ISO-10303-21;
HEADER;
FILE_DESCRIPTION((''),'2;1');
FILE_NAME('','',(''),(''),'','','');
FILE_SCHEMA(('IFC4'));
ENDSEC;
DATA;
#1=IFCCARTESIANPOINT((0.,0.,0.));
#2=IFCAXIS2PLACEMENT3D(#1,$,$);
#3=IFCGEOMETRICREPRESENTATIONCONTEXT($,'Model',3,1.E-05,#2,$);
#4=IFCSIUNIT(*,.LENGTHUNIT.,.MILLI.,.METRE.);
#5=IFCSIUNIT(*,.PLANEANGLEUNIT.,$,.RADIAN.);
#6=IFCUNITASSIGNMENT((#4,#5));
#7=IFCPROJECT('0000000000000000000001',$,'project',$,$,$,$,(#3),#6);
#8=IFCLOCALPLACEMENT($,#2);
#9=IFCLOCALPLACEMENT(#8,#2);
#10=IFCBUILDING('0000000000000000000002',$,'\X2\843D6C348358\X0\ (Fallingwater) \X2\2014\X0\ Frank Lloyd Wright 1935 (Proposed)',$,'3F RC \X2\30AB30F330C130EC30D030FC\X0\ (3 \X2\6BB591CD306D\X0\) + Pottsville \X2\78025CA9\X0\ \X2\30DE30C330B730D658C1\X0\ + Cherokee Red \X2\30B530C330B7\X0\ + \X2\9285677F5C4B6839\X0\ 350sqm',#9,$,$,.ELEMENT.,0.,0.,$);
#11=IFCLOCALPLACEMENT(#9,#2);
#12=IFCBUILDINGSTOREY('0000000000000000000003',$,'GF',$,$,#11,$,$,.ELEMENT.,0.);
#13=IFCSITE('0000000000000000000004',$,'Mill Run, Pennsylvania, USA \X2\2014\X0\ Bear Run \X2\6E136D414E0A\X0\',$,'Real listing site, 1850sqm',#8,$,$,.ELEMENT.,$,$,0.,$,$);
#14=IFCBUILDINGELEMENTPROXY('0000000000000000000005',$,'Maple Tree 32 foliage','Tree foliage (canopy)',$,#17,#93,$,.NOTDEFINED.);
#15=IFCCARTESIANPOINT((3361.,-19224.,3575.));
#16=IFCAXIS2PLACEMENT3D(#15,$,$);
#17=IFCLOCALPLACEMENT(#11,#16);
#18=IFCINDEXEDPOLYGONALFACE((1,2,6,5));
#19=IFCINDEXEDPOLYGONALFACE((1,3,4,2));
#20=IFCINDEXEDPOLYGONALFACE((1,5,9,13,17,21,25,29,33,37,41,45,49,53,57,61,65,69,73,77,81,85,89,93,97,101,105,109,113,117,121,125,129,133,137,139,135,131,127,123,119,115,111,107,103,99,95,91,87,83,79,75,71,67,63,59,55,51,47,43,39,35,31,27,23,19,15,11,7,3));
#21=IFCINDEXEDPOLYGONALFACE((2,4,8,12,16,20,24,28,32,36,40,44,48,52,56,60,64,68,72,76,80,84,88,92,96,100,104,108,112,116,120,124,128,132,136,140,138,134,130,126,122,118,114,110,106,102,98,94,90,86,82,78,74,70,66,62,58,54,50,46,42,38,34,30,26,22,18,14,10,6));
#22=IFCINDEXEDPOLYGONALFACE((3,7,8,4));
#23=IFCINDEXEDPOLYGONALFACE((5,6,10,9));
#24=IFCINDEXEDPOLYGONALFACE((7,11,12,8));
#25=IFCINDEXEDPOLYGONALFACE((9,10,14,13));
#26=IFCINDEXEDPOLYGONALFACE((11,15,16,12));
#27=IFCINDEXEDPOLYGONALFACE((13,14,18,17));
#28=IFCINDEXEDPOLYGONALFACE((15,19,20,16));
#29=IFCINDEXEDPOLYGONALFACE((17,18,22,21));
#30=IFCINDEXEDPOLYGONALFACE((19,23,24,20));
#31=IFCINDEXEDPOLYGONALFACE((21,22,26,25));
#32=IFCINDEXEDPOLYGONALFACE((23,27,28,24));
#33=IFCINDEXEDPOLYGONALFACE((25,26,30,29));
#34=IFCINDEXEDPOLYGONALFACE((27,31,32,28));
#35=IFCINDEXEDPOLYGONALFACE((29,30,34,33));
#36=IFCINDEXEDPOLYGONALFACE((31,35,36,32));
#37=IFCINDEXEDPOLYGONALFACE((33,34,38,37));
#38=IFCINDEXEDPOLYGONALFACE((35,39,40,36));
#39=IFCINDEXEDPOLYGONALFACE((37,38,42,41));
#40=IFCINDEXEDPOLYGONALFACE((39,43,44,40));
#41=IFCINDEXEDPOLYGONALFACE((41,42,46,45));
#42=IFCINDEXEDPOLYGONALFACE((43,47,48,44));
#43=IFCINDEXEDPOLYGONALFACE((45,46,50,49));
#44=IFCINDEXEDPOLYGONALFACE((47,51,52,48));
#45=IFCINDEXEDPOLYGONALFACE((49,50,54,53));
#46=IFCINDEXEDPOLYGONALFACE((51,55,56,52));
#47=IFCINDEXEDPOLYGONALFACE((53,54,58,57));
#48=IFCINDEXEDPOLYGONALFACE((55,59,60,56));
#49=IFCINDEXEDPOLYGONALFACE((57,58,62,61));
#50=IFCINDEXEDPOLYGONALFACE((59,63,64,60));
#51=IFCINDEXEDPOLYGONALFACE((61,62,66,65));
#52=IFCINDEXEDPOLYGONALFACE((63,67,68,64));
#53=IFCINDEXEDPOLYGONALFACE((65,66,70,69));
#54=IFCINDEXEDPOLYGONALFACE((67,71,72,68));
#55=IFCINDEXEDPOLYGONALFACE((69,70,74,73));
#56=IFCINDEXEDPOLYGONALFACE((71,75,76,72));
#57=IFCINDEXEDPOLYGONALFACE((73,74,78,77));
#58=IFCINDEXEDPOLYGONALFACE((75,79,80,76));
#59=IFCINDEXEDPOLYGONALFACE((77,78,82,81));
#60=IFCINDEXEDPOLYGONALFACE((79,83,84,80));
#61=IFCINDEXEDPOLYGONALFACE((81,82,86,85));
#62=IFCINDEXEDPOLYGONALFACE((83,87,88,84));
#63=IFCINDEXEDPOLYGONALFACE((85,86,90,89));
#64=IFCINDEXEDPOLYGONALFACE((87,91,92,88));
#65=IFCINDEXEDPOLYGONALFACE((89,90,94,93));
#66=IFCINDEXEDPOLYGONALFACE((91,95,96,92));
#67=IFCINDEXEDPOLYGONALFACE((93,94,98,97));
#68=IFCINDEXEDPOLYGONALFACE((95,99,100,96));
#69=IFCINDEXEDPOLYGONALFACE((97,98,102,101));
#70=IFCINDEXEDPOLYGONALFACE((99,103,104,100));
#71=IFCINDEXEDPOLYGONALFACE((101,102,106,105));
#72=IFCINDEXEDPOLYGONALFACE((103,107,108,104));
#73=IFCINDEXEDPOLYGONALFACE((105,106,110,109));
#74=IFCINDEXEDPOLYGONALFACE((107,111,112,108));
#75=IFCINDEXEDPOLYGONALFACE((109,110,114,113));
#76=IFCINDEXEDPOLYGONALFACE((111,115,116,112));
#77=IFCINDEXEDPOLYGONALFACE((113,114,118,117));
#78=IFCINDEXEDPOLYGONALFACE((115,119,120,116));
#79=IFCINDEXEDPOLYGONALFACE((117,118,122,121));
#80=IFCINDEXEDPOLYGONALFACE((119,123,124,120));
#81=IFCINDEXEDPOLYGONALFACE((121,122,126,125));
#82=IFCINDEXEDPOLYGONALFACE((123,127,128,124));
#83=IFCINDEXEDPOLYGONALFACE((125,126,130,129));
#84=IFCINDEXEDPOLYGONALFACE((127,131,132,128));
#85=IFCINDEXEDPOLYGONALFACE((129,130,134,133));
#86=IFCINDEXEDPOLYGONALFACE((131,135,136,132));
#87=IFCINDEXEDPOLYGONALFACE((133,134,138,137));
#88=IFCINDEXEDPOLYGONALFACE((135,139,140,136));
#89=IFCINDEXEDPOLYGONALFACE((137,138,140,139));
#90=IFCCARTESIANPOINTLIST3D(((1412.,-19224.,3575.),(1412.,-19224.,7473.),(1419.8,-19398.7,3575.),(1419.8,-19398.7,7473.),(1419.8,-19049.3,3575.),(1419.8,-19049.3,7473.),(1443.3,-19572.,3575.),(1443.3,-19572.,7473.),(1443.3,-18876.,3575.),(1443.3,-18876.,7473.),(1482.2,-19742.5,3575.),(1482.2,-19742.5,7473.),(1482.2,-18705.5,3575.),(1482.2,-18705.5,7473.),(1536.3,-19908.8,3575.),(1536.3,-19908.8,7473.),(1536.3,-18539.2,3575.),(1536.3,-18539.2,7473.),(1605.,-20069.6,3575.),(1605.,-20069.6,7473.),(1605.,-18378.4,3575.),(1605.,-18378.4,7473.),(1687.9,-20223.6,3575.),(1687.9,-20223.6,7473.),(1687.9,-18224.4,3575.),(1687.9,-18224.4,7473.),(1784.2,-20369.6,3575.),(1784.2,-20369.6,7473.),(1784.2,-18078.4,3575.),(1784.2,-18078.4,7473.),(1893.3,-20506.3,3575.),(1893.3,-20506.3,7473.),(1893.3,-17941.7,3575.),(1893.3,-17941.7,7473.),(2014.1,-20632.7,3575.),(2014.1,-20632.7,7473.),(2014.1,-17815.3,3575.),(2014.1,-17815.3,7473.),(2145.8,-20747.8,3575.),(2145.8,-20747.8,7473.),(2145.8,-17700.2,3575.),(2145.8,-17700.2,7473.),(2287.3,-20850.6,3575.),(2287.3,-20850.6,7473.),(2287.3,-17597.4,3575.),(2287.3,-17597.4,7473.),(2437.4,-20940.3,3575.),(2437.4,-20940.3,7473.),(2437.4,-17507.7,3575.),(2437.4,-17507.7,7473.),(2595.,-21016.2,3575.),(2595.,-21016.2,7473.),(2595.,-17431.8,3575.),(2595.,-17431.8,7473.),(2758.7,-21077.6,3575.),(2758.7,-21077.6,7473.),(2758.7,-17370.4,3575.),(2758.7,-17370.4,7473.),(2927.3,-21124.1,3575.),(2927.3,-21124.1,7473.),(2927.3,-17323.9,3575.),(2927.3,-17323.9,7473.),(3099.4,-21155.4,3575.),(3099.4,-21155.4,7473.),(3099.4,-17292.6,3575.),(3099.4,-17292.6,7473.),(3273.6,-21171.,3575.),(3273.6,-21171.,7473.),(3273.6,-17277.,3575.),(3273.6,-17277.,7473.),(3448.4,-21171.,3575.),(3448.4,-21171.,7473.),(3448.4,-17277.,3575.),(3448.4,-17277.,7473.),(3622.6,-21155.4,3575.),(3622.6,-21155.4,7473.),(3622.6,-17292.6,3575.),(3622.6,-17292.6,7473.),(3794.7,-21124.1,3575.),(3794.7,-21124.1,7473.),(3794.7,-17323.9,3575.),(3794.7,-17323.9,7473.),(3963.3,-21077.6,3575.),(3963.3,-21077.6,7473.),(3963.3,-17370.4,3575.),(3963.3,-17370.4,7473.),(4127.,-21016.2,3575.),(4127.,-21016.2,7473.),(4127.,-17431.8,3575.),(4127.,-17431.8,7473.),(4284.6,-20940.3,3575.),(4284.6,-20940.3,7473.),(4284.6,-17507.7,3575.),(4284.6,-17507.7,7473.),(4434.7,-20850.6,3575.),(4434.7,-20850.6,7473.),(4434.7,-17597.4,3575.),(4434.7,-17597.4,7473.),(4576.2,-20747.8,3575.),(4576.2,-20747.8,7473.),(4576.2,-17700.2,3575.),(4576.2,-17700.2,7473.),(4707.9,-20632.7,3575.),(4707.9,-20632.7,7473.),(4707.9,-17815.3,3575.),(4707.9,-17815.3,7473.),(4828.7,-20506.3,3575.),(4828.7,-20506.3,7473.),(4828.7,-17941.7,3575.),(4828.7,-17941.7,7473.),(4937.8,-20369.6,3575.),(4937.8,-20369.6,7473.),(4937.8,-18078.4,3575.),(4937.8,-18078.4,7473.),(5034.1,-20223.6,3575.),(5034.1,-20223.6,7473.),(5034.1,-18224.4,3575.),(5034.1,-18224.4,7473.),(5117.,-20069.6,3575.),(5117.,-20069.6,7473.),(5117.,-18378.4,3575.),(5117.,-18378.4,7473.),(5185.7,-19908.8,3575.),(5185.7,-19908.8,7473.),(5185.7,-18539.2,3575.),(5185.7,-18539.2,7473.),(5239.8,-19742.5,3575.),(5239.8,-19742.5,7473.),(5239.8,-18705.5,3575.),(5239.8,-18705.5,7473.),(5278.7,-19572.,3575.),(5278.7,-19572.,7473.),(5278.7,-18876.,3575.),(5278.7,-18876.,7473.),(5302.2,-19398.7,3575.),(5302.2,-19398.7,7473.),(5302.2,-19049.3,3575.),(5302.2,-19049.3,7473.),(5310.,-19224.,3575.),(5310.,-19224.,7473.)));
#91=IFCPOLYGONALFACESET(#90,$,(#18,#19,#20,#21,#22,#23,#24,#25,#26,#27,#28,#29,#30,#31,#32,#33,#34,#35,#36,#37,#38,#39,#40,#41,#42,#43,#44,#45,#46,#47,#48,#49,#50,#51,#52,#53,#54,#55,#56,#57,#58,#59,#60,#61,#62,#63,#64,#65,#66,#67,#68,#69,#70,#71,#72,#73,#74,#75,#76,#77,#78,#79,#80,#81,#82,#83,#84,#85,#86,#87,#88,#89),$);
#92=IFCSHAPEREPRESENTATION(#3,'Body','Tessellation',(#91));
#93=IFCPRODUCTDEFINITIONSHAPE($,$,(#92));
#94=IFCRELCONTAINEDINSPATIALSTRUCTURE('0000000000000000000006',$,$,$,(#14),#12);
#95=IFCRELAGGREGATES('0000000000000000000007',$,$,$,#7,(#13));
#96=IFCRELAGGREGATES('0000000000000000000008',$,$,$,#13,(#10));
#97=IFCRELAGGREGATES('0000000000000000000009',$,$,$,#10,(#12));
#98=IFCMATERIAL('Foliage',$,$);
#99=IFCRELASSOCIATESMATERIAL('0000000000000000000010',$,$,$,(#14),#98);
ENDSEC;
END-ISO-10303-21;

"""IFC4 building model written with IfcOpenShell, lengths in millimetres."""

from ifc_helpers import new_model, si_unit, frame, origin, origin_2d, place, context, project, spatial, circle, extrude, material, element, save


model = new_model("IFC4")

# Units and contexts
model_context = context("Model", 3, precision=1e-05, world=origin())
ifc_project = project(units=[si_unit("LENGTHUNIT", "METRE", prefix="MILLI"), si_unit("PLANEANGLEUNIT", "RADIAN")], contexts=[model_context])

# Site, building, storey
site_placement = place(None, origin())
site = spatial("IfcSite", under=ifc_project, at=site_placement, Name="Mill Run, Pennsylvania, USA — Bear Run 渓流上", ObjectType="Real listing site, 1850sqm", CompositionType="ELEMENT", RefElevation=0.0)
building_placement = place(site_placement, origin())
building = spatial("IfcBuilding", under=site, at=building_placement, Name="落水荘 (Fallingwater) — Frank Lloyd Wright 1935 (Proposed)", ObjectType="3F RC カンチレバー (3 段重ね) + Pottsville 砂岩 マッシブ壁 + Cherokee Red サッシ + 銅板屋根 350sqm", CompositionType="ELEMENT", ElevationOfRefHeight=0.0, ElevationOfTerrain=0.0)
storey_placement = place(building_placement, origin())
storey = spatial("IfcBuildingStorey", under=building, at=storey_placement, Name="GF", CompositionType="ELEMENT", Elevation=0.0)

# Building element proxy
ifc_material_1 = material(Name="Foliage")
proxy_1_placement = place(storey_placement, frame((3361.0, -19224.0, 3575.0)))
element("IfcBuildingElementProxy", 1, at=proxy_1_placement, inside=storey, material=ifc_material_1, Name="Maple Tree 32 foliage", Description="Tree foliage (canopy)", PredefinedType="NOTDEFINED", context=model_context, shape_type="SweptSolid", body=[
    extrude(circle(Radius=1949.0, at=origin_2d()), frame((3361.0, -19224.0, 3575.0)), (0.0, 0.0, 1.0), 3898.0),
])

save(model, "model.ifc")
